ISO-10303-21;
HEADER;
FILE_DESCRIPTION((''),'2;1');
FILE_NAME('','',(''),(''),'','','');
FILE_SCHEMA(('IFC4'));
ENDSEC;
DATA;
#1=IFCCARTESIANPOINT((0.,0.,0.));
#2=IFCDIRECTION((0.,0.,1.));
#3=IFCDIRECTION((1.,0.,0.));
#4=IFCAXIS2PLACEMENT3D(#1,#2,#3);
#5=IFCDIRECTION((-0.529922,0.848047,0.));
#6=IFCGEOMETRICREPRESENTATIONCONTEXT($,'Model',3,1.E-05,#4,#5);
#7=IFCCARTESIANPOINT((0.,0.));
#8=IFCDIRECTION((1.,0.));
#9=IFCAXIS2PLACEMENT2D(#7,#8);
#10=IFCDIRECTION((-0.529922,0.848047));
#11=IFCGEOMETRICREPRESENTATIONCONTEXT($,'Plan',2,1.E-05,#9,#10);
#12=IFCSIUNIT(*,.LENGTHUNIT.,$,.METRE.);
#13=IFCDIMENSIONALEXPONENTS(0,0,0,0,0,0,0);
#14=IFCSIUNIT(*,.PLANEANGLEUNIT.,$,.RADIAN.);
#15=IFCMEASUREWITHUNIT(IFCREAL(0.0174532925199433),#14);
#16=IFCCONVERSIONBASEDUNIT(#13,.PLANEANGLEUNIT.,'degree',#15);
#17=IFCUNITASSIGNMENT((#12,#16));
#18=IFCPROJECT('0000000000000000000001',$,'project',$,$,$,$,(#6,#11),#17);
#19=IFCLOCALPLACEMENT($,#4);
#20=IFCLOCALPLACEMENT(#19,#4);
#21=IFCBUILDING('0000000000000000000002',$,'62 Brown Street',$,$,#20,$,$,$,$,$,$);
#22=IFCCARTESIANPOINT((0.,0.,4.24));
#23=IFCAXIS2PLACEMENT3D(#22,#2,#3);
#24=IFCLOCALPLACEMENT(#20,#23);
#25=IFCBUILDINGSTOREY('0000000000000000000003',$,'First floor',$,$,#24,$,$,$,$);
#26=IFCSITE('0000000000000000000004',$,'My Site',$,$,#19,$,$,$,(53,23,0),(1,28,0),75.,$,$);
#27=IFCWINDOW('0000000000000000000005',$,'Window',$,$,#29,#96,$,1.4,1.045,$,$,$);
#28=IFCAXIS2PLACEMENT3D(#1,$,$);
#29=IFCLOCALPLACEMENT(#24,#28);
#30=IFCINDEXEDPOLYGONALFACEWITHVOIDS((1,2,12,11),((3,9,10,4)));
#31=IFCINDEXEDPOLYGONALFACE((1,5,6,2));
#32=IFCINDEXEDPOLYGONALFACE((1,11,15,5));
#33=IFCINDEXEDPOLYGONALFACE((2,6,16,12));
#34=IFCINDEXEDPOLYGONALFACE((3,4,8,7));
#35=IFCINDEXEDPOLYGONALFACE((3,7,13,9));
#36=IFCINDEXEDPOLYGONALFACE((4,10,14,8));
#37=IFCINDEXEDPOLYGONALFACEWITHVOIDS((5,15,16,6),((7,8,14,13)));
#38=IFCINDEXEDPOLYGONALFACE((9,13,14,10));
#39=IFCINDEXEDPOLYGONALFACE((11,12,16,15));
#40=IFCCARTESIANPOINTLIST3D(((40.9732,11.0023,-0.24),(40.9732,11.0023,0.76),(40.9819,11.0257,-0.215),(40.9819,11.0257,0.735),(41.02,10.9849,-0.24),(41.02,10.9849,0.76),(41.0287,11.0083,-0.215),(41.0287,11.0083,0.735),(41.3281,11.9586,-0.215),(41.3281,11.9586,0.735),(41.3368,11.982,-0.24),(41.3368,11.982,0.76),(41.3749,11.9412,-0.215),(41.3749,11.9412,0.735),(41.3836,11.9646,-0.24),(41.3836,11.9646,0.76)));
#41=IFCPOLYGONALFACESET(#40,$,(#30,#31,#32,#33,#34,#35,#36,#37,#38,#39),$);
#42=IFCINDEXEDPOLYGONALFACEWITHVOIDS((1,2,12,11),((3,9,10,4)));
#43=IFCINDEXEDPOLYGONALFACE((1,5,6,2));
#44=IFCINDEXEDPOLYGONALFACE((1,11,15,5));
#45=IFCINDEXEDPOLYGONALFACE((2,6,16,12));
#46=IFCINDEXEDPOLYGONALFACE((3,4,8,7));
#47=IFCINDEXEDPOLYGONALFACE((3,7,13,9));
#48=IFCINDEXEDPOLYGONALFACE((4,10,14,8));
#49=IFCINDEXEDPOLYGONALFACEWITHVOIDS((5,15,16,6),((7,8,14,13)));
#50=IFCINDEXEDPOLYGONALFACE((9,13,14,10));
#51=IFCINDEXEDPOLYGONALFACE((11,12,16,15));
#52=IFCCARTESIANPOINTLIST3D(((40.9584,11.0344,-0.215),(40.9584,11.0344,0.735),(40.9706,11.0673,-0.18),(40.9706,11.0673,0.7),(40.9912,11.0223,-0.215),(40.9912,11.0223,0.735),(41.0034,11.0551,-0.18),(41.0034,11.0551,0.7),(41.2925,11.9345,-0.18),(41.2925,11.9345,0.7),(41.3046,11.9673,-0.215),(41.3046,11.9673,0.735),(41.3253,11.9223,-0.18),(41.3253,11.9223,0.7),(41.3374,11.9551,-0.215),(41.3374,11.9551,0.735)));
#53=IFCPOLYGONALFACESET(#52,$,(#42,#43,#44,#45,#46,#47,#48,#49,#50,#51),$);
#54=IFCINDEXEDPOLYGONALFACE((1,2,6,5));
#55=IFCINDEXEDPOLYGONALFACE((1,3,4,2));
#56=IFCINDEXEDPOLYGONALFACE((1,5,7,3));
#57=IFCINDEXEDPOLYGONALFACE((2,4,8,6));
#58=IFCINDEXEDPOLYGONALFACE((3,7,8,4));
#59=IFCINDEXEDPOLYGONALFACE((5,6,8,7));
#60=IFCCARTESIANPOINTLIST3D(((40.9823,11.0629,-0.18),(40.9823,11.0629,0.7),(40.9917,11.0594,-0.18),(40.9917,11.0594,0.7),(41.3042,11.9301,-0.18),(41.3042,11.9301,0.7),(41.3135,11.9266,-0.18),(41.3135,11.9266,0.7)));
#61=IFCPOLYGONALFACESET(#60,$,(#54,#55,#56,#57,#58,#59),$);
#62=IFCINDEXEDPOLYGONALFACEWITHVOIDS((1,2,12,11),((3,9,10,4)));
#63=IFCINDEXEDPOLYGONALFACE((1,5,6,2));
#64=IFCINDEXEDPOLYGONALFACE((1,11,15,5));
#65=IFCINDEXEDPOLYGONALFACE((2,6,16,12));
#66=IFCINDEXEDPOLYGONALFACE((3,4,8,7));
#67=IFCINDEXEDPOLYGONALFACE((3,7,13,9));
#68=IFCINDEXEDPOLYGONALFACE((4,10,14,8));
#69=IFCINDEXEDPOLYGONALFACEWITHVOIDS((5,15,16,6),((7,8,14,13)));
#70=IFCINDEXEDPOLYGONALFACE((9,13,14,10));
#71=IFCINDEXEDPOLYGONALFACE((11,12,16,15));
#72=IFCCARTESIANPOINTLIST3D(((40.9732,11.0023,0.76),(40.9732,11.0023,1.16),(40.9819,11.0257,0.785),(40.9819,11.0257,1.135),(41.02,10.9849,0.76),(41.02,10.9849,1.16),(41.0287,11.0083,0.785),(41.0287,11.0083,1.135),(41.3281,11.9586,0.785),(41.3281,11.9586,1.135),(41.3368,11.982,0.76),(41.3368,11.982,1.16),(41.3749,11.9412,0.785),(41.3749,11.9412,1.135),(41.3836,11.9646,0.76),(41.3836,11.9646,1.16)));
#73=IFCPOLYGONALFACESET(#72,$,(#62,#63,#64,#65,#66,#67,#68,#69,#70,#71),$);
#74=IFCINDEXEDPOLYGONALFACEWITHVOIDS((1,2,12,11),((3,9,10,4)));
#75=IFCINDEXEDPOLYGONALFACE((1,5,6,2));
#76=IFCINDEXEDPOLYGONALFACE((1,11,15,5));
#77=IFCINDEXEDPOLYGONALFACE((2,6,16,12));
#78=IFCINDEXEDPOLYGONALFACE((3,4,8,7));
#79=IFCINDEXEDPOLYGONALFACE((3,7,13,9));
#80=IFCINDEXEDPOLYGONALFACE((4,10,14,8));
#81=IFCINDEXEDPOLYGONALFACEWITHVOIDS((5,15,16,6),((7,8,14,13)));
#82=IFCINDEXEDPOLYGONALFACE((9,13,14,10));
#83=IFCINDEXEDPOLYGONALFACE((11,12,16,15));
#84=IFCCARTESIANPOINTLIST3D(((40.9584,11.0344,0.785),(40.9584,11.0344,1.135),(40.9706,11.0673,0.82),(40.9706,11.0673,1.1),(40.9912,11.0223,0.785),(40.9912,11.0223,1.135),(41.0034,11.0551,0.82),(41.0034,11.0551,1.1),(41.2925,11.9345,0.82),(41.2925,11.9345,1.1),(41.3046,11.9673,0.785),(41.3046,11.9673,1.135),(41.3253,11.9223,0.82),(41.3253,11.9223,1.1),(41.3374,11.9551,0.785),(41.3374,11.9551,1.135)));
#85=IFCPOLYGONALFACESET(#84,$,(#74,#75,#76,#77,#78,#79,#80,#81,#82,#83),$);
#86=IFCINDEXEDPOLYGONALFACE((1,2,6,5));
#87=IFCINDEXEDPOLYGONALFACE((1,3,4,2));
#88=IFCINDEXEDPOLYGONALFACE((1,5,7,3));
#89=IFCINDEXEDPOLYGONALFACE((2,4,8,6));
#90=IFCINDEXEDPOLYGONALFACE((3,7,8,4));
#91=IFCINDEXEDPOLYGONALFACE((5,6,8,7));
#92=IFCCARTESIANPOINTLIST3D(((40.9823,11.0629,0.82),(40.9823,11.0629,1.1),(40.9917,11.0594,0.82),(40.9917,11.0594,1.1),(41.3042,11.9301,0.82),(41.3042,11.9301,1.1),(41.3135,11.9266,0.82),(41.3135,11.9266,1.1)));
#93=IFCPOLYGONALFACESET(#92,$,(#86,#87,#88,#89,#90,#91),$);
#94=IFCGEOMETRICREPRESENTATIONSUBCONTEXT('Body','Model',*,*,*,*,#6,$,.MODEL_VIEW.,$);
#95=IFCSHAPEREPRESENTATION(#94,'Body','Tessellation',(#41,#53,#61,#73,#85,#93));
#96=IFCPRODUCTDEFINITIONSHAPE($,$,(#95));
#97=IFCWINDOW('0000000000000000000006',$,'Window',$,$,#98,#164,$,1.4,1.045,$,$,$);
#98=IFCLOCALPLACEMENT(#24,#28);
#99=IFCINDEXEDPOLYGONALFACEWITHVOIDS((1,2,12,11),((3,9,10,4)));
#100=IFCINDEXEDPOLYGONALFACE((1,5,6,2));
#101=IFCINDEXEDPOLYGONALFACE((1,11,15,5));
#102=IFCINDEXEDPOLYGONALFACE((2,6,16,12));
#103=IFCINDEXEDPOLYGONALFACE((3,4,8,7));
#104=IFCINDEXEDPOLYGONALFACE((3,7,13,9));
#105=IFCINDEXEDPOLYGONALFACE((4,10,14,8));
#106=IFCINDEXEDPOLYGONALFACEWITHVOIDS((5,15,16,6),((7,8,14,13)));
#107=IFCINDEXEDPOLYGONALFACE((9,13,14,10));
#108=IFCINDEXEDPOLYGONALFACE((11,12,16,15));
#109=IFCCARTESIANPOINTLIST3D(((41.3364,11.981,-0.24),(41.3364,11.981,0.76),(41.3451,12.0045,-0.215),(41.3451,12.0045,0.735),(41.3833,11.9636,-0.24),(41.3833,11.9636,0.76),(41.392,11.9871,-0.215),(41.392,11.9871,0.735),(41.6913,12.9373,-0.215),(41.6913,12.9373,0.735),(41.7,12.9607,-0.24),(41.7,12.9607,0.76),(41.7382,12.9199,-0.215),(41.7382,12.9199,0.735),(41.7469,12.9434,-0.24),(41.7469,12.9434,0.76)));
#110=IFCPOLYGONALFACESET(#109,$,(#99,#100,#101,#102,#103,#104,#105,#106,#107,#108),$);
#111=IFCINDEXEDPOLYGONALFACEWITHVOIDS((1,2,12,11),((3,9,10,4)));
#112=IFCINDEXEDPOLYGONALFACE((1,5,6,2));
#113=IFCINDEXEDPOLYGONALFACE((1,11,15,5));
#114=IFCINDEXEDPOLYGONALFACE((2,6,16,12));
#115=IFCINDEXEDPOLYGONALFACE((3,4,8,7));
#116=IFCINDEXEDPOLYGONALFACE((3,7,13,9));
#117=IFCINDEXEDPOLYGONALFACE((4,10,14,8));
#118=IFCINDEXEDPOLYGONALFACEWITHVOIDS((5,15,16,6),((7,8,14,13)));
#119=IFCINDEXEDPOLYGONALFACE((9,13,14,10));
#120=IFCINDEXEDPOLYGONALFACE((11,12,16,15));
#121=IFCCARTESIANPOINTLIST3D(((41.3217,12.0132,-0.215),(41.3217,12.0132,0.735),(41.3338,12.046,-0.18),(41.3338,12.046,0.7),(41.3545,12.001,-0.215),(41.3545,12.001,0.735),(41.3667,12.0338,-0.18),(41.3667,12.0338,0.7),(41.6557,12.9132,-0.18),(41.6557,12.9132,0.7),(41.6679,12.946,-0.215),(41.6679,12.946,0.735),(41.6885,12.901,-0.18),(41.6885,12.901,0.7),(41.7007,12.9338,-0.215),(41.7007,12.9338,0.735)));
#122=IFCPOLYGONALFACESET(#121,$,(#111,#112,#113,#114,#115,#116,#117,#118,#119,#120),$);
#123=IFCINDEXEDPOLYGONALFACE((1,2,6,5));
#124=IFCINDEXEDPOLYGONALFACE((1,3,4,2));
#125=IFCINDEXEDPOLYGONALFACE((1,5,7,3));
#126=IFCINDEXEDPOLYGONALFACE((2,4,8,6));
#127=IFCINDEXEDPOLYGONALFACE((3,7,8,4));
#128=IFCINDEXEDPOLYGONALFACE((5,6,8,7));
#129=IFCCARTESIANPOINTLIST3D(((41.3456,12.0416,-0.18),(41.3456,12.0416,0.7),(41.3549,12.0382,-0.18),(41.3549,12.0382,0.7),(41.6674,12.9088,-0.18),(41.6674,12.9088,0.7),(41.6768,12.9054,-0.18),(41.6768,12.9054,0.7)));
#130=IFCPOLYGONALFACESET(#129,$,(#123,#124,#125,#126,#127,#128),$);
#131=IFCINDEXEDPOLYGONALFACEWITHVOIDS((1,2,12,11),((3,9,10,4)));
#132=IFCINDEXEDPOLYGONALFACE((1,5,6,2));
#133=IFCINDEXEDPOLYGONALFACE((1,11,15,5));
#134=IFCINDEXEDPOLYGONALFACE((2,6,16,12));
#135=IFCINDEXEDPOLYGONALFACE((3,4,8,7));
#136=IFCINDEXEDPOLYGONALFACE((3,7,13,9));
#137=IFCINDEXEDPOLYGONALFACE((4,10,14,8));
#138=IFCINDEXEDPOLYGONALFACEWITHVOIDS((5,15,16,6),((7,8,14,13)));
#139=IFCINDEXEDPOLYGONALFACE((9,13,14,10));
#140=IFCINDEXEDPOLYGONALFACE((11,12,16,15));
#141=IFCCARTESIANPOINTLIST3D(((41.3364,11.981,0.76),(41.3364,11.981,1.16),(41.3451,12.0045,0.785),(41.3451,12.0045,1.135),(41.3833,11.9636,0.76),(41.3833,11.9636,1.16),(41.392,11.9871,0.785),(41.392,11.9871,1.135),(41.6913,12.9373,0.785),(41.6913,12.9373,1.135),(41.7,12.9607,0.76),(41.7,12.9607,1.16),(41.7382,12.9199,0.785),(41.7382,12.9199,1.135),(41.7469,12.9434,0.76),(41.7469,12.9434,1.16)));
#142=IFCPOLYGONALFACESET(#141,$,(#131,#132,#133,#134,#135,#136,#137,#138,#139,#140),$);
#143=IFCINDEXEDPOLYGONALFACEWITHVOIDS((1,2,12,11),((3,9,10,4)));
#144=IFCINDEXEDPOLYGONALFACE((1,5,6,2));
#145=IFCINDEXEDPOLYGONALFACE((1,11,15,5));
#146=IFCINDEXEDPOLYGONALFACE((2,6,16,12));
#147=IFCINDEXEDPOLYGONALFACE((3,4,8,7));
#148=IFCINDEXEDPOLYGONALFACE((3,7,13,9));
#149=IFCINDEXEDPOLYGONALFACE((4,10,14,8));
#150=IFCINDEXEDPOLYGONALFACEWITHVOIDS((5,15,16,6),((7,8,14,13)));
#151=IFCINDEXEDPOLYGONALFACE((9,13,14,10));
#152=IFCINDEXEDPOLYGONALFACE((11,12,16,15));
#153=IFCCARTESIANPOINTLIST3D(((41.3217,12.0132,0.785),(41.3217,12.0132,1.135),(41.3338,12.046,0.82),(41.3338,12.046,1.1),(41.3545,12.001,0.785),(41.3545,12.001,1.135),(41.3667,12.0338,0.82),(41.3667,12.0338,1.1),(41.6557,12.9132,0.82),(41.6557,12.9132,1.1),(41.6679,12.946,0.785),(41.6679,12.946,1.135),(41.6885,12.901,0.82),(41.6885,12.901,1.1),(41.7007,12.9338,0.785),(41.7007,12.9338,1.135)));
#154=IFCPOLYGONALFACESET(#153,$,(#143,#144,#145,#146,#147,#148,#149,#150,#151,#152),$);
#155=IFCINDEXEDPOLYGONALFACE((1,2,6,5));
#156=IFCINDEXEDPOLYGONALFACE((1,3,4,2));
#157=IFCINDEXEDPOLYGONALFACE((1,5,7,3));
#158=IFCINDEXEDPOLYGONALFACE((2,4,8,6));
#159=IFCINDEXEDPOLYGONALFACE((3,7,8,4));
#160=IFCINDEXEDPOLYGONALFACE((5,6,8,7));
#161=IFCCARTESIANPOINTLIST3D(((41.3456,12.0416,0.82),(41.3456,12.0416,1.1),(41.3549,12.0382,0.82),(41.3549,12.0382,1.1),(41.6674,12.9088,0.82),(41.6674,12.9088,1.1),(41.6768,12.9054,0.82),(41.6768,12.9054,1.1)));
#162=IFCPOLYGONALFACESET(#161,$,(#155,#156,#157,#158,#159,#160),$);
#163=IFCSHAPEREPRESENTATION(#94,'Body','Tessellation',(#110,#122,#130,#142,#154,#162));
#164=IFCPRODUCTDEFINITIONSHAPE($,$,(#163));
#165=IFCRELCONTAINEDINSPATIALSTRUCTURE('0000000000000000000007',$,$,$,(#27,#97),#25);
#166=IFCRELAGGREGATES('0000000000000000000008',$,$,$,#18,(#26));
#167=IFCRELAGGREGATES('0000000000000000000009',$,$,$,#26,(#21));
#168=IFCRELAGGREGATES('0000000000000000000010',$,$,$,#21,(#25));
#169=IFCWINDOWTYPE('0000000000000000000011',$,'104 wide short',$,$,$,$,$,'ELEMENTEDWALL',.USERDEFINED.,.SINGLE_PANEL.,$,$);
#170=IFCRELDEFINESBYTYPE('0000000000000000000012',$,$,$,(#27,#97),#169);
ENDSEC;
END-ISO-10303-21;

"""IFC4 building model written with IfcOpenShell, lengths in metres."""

from ifc_helpers import new_model, entity, si_unit, converted_unit, direction, frame, origin_with_axes, origin_2d_with_axis, place, context, subcontext, project, spatial, line, indexed_curve, outline, extrude, shape, source, transform, mapped, type_object, type_shapes, element, save


model = new_model("IFC4")

# Units and contexts
model_context = context("Model", 3, precision=1e-05, world=origin_with_axes(), true_north=direction((-0.529922, 0.848047, 0.0)))
plan_context = context("Plan", 2, precision=1e-05, world=origin_2d_with_axis(), true_north=direction((-0.529922, 0.848047)))
body_context_1 = subcontext(model_context, "Body", "Model", "MODEL_VIEW")
body_context_2 = subcontext(plan_context, "Body", "Plan", "PLAN_VIEW")
ifc_project = project(units=[si_unit("LENGTHUNIT", "METRE"), converted_unit("PLANEANGLEUNIT", "degree", entity("IfcReal", 0.0174532925199433), si_unit("PLANEANGLEUNIT", "RADIAN"), dimensions=[0, 0, 0, 0, 0, 0, 0])], contexts=[model_context, plan_context])

# Site, building, storey
site_placement = place(None, origin_with_axes())
site = spatial("IfcSite", under=ifc_project, at=site_placement, Name="My Site", RefLatitude=(53, 23, 0), RefLongitude=(1, 28, 0), RefElevation=75.0)
building_placement = place(site_placement, origin_with_axes())
building = spatial("IfcBuilding", under=site, at=building_placement, Name="62 Brown Street")
storey_placement = place(building_placement, frame((0.0, 0.0, 4.24), z_axis=(0.0, 0.0, 1.0), x_axis=(1.0, 0.0, 0.0)))
storey = spatial("IfcBuildingStorey", under=building, at=storey_placement, Name="First floor")

# Windows
window_type = type_object("IfcWindowType", Name="104 wide short", ElementType="ELEMENTEDWALL", PartitioningType="SINGLE_PANEL", PredefinedType="USERDEFINED")
shared_shape_1 = source(origin_with_axes(), body_context_1, "Body", "SweptSolid", [
    extrude(outline(indexed_curve([(0.0, 0.0), (1.045, 0.0), (1.045, 1.0), (0.0, 1.0)], segments=[line(1, 2, 3, 4, 1)]), holes=[indexed_curve([(0.025, 0.025), (1.02, 0.025), (1.02, 0.975), (0.025, 0.975)], segments=[line(1, 2, 3, 4, 1)])]), frame((0.0, 0.15, 0.0), z_axis=(0.0, -1.0, 0.0), x_axis=(1.0, 0.0, 0.0)), (0.0, 0.0, -1.0), 0.05),
    extrude(outline(indexed_curve([(0.0, 0.0), (0.995, 0.0), (0.995, 0.95), (0.0, 0.95)], segments=[line(1, 2, 3, 4, 1)]), holes=[indexed_curve([(0.035, 0.035), (0.96, 0.035), (0.96, 0.915), (0.035, 0.915)], segments=[line(1, 2, 3, 4, 1)])]), frame((0.025, 0.19, 0.025), z_axis=(0.0, -1.0, 0.0), x_axis=(1.0, 0.0, 0.0)), (0.0, 0.0, -1.0), 0.035),
    extrude(outline(indexed_curve([(0.035, 0.035), (0.96, 0.035), (0.96, 0.915), (0.035, 0.915)], segments=[line(1, 2, 3, 4, 1)])), frame((0.025, 0.2025, 0.025), z_axis=(0.0, -1.0, 0.0), x_axis=(1.0, 0.0, 0.0)), (0.0, 0.0, -1.0), 0.01),
    extrude(outline(indexed_curve([(0.0, 0.0), (1.045, 0.0), (1.045, 0.4), (0.0, 0.4)], segments=[line(1, 2, 3, 4, 1)]), holes=[indexed_curve([(0.025, 0.025), (1.02, 0.025), (1.02, 0.375), (0.025, 0.375)], segments=[line(1, 2, 3, 4, 1)])]), frame((0.0, 0.15, 1.0), z_axis=(0.0, -1.0, 0.0), x_axis=(1.0, 0.0, 0.0)), (0.0, 0.0, -1.0), 0.05),
    extrude(outline(indexed_curve([(0.0, 0.0), (0.995, 0.0), (0.995, 0.35), (0.0, 0.35)], segments=[line(1, 2, 3, 4, 1)]), holes=[indexed_curve([(0.035, 0.035), (0.96, 0.035), (0.96, 0.315), (0.035, 0.315)], segments=[line(1, 2, 3, 4, 1)])]), frame((0.025, 0.19, 1.025), z_axis=(0.0, -1.0, 0.0), x_axis=(1.0, 0.0, 0.0)), (0.0, 0.0, -1.0), 0.035),
    extrude(outline(indexed_curve([(0.035, 0.035), (0.96, 0.035), (0.96, 0.315), (0.035, 0.315)], segments=[line(1, 2, 3, 4, 1)])), frame((0.025, 0.2025, 1.025), z_axis=(0.0, -1.0, 0.0), x_axis=(1.0, 0.0, 0.0)), (0.0, 0.0, -1.0), 0.01),
])
shared_shape_2 = source(origin_with_axes(), body_context_2, "Body", "Curve2D", [
    entity("IfcIndexedPolyCurve", entity("IfcCartesianPointList2D", [[0.025, 0.15], [1.02, 0.15]])),
    entity("IfcIndexedPolyCurve", entity("IfcCartesianPointList2D", [[0.0, 0.2], [0.025, 0.2], [0.025, 0.15], [0.0, 0.15]]), [entity("IfcLineIndex", [1, 2, 3, 4, 1])]),
    entity("IfcIndexedPolyCurve", entity("IfcCartesianPointList2D", [[1.045, 0.2], [1.02, 0.2], [1.02, 0.15], [1.045, 0.15]]), [entity("IfcLineIndex", [1, 2, 3, 4, 1])]),
    entity("IfcIndexedPolyCurve", entity("IfcCartesianPointList2D", [[0.025, 0.19], [0.06, 0.19], [0.06, 0.225], [0.025, 0.225]]), [entity("IfcLineIndex", [1, 2, 3, 4, 1])]),
    entity("IfcIndexedPolyCurve", entity("IfcCartesianPointList2D", [[1.02, 0.19], [0.985, 0.19], [0.985, 0.225], [1.02, 0.225]]), [entity("IfcLineIndex", [1, 2, 3, 4, 1])]),
    entity("IfcIndexedPolyCurve", entity("IfcCartesianPointList2D", [[0.06, 0.19], [0.985, 0.19]])),
    entity("IfcIndexedPolyCurve", entity("IfcCartesianPointList2D", [[0.06, 0.225], [0.985, 0.225]])),
    entity("IfcIndexedPolyCurve", entity("IfcCartesianPointList2D", [[0.06, 0.2075], [0.985, 0.2075]])),
])
type_shapes(window_type, [shared_shape_1, shared_shape_2])
for number, where, z_axis, x_axis, name in (
    (1, (41.1607, 10.9327, -0.24), (0.0, 0.0, 1.0), (0.347944, 0.937515, 0.0), "Window"),
    (2, (41.5239, 11.9115, -0.24), (0.0, 0.0, 1.0), (0.347944, 0.937515, 0.0), "Window"),
):
    element("IfcWindow", number, at=place(storey_placement, frame(where, z_axis=z_axis, x_axis=x_axis)), inside=storey, type_object=window_type, Name=name, OverallHeight=1.4, OverallWidth=1.045, shapes=[
        shape(body_context_1, "Body", "MappedRepresentation", [mapped(shared_shape_1, transform((0.0, 0.0, 0.0), x_axis=(1.0, 0.0, 0.0), y_axis=(0.0, 1.0, 0.0), z_axis=(0.0, 0.0, 1.0), scale=1.0))]),
        shape(body_context_2, "Body", "MappedRepresentation", [mapped(shared_shape_2, transform((0.0, 0.0, 0.0), x_axis=(1.0, 0.0, 0.0), y_axis=(0.0, 1.0, 0.0), z_axis=(0.0, 0.0, 1.0), scale=1.0))]),
    ])

save(model, "model.ifc")
